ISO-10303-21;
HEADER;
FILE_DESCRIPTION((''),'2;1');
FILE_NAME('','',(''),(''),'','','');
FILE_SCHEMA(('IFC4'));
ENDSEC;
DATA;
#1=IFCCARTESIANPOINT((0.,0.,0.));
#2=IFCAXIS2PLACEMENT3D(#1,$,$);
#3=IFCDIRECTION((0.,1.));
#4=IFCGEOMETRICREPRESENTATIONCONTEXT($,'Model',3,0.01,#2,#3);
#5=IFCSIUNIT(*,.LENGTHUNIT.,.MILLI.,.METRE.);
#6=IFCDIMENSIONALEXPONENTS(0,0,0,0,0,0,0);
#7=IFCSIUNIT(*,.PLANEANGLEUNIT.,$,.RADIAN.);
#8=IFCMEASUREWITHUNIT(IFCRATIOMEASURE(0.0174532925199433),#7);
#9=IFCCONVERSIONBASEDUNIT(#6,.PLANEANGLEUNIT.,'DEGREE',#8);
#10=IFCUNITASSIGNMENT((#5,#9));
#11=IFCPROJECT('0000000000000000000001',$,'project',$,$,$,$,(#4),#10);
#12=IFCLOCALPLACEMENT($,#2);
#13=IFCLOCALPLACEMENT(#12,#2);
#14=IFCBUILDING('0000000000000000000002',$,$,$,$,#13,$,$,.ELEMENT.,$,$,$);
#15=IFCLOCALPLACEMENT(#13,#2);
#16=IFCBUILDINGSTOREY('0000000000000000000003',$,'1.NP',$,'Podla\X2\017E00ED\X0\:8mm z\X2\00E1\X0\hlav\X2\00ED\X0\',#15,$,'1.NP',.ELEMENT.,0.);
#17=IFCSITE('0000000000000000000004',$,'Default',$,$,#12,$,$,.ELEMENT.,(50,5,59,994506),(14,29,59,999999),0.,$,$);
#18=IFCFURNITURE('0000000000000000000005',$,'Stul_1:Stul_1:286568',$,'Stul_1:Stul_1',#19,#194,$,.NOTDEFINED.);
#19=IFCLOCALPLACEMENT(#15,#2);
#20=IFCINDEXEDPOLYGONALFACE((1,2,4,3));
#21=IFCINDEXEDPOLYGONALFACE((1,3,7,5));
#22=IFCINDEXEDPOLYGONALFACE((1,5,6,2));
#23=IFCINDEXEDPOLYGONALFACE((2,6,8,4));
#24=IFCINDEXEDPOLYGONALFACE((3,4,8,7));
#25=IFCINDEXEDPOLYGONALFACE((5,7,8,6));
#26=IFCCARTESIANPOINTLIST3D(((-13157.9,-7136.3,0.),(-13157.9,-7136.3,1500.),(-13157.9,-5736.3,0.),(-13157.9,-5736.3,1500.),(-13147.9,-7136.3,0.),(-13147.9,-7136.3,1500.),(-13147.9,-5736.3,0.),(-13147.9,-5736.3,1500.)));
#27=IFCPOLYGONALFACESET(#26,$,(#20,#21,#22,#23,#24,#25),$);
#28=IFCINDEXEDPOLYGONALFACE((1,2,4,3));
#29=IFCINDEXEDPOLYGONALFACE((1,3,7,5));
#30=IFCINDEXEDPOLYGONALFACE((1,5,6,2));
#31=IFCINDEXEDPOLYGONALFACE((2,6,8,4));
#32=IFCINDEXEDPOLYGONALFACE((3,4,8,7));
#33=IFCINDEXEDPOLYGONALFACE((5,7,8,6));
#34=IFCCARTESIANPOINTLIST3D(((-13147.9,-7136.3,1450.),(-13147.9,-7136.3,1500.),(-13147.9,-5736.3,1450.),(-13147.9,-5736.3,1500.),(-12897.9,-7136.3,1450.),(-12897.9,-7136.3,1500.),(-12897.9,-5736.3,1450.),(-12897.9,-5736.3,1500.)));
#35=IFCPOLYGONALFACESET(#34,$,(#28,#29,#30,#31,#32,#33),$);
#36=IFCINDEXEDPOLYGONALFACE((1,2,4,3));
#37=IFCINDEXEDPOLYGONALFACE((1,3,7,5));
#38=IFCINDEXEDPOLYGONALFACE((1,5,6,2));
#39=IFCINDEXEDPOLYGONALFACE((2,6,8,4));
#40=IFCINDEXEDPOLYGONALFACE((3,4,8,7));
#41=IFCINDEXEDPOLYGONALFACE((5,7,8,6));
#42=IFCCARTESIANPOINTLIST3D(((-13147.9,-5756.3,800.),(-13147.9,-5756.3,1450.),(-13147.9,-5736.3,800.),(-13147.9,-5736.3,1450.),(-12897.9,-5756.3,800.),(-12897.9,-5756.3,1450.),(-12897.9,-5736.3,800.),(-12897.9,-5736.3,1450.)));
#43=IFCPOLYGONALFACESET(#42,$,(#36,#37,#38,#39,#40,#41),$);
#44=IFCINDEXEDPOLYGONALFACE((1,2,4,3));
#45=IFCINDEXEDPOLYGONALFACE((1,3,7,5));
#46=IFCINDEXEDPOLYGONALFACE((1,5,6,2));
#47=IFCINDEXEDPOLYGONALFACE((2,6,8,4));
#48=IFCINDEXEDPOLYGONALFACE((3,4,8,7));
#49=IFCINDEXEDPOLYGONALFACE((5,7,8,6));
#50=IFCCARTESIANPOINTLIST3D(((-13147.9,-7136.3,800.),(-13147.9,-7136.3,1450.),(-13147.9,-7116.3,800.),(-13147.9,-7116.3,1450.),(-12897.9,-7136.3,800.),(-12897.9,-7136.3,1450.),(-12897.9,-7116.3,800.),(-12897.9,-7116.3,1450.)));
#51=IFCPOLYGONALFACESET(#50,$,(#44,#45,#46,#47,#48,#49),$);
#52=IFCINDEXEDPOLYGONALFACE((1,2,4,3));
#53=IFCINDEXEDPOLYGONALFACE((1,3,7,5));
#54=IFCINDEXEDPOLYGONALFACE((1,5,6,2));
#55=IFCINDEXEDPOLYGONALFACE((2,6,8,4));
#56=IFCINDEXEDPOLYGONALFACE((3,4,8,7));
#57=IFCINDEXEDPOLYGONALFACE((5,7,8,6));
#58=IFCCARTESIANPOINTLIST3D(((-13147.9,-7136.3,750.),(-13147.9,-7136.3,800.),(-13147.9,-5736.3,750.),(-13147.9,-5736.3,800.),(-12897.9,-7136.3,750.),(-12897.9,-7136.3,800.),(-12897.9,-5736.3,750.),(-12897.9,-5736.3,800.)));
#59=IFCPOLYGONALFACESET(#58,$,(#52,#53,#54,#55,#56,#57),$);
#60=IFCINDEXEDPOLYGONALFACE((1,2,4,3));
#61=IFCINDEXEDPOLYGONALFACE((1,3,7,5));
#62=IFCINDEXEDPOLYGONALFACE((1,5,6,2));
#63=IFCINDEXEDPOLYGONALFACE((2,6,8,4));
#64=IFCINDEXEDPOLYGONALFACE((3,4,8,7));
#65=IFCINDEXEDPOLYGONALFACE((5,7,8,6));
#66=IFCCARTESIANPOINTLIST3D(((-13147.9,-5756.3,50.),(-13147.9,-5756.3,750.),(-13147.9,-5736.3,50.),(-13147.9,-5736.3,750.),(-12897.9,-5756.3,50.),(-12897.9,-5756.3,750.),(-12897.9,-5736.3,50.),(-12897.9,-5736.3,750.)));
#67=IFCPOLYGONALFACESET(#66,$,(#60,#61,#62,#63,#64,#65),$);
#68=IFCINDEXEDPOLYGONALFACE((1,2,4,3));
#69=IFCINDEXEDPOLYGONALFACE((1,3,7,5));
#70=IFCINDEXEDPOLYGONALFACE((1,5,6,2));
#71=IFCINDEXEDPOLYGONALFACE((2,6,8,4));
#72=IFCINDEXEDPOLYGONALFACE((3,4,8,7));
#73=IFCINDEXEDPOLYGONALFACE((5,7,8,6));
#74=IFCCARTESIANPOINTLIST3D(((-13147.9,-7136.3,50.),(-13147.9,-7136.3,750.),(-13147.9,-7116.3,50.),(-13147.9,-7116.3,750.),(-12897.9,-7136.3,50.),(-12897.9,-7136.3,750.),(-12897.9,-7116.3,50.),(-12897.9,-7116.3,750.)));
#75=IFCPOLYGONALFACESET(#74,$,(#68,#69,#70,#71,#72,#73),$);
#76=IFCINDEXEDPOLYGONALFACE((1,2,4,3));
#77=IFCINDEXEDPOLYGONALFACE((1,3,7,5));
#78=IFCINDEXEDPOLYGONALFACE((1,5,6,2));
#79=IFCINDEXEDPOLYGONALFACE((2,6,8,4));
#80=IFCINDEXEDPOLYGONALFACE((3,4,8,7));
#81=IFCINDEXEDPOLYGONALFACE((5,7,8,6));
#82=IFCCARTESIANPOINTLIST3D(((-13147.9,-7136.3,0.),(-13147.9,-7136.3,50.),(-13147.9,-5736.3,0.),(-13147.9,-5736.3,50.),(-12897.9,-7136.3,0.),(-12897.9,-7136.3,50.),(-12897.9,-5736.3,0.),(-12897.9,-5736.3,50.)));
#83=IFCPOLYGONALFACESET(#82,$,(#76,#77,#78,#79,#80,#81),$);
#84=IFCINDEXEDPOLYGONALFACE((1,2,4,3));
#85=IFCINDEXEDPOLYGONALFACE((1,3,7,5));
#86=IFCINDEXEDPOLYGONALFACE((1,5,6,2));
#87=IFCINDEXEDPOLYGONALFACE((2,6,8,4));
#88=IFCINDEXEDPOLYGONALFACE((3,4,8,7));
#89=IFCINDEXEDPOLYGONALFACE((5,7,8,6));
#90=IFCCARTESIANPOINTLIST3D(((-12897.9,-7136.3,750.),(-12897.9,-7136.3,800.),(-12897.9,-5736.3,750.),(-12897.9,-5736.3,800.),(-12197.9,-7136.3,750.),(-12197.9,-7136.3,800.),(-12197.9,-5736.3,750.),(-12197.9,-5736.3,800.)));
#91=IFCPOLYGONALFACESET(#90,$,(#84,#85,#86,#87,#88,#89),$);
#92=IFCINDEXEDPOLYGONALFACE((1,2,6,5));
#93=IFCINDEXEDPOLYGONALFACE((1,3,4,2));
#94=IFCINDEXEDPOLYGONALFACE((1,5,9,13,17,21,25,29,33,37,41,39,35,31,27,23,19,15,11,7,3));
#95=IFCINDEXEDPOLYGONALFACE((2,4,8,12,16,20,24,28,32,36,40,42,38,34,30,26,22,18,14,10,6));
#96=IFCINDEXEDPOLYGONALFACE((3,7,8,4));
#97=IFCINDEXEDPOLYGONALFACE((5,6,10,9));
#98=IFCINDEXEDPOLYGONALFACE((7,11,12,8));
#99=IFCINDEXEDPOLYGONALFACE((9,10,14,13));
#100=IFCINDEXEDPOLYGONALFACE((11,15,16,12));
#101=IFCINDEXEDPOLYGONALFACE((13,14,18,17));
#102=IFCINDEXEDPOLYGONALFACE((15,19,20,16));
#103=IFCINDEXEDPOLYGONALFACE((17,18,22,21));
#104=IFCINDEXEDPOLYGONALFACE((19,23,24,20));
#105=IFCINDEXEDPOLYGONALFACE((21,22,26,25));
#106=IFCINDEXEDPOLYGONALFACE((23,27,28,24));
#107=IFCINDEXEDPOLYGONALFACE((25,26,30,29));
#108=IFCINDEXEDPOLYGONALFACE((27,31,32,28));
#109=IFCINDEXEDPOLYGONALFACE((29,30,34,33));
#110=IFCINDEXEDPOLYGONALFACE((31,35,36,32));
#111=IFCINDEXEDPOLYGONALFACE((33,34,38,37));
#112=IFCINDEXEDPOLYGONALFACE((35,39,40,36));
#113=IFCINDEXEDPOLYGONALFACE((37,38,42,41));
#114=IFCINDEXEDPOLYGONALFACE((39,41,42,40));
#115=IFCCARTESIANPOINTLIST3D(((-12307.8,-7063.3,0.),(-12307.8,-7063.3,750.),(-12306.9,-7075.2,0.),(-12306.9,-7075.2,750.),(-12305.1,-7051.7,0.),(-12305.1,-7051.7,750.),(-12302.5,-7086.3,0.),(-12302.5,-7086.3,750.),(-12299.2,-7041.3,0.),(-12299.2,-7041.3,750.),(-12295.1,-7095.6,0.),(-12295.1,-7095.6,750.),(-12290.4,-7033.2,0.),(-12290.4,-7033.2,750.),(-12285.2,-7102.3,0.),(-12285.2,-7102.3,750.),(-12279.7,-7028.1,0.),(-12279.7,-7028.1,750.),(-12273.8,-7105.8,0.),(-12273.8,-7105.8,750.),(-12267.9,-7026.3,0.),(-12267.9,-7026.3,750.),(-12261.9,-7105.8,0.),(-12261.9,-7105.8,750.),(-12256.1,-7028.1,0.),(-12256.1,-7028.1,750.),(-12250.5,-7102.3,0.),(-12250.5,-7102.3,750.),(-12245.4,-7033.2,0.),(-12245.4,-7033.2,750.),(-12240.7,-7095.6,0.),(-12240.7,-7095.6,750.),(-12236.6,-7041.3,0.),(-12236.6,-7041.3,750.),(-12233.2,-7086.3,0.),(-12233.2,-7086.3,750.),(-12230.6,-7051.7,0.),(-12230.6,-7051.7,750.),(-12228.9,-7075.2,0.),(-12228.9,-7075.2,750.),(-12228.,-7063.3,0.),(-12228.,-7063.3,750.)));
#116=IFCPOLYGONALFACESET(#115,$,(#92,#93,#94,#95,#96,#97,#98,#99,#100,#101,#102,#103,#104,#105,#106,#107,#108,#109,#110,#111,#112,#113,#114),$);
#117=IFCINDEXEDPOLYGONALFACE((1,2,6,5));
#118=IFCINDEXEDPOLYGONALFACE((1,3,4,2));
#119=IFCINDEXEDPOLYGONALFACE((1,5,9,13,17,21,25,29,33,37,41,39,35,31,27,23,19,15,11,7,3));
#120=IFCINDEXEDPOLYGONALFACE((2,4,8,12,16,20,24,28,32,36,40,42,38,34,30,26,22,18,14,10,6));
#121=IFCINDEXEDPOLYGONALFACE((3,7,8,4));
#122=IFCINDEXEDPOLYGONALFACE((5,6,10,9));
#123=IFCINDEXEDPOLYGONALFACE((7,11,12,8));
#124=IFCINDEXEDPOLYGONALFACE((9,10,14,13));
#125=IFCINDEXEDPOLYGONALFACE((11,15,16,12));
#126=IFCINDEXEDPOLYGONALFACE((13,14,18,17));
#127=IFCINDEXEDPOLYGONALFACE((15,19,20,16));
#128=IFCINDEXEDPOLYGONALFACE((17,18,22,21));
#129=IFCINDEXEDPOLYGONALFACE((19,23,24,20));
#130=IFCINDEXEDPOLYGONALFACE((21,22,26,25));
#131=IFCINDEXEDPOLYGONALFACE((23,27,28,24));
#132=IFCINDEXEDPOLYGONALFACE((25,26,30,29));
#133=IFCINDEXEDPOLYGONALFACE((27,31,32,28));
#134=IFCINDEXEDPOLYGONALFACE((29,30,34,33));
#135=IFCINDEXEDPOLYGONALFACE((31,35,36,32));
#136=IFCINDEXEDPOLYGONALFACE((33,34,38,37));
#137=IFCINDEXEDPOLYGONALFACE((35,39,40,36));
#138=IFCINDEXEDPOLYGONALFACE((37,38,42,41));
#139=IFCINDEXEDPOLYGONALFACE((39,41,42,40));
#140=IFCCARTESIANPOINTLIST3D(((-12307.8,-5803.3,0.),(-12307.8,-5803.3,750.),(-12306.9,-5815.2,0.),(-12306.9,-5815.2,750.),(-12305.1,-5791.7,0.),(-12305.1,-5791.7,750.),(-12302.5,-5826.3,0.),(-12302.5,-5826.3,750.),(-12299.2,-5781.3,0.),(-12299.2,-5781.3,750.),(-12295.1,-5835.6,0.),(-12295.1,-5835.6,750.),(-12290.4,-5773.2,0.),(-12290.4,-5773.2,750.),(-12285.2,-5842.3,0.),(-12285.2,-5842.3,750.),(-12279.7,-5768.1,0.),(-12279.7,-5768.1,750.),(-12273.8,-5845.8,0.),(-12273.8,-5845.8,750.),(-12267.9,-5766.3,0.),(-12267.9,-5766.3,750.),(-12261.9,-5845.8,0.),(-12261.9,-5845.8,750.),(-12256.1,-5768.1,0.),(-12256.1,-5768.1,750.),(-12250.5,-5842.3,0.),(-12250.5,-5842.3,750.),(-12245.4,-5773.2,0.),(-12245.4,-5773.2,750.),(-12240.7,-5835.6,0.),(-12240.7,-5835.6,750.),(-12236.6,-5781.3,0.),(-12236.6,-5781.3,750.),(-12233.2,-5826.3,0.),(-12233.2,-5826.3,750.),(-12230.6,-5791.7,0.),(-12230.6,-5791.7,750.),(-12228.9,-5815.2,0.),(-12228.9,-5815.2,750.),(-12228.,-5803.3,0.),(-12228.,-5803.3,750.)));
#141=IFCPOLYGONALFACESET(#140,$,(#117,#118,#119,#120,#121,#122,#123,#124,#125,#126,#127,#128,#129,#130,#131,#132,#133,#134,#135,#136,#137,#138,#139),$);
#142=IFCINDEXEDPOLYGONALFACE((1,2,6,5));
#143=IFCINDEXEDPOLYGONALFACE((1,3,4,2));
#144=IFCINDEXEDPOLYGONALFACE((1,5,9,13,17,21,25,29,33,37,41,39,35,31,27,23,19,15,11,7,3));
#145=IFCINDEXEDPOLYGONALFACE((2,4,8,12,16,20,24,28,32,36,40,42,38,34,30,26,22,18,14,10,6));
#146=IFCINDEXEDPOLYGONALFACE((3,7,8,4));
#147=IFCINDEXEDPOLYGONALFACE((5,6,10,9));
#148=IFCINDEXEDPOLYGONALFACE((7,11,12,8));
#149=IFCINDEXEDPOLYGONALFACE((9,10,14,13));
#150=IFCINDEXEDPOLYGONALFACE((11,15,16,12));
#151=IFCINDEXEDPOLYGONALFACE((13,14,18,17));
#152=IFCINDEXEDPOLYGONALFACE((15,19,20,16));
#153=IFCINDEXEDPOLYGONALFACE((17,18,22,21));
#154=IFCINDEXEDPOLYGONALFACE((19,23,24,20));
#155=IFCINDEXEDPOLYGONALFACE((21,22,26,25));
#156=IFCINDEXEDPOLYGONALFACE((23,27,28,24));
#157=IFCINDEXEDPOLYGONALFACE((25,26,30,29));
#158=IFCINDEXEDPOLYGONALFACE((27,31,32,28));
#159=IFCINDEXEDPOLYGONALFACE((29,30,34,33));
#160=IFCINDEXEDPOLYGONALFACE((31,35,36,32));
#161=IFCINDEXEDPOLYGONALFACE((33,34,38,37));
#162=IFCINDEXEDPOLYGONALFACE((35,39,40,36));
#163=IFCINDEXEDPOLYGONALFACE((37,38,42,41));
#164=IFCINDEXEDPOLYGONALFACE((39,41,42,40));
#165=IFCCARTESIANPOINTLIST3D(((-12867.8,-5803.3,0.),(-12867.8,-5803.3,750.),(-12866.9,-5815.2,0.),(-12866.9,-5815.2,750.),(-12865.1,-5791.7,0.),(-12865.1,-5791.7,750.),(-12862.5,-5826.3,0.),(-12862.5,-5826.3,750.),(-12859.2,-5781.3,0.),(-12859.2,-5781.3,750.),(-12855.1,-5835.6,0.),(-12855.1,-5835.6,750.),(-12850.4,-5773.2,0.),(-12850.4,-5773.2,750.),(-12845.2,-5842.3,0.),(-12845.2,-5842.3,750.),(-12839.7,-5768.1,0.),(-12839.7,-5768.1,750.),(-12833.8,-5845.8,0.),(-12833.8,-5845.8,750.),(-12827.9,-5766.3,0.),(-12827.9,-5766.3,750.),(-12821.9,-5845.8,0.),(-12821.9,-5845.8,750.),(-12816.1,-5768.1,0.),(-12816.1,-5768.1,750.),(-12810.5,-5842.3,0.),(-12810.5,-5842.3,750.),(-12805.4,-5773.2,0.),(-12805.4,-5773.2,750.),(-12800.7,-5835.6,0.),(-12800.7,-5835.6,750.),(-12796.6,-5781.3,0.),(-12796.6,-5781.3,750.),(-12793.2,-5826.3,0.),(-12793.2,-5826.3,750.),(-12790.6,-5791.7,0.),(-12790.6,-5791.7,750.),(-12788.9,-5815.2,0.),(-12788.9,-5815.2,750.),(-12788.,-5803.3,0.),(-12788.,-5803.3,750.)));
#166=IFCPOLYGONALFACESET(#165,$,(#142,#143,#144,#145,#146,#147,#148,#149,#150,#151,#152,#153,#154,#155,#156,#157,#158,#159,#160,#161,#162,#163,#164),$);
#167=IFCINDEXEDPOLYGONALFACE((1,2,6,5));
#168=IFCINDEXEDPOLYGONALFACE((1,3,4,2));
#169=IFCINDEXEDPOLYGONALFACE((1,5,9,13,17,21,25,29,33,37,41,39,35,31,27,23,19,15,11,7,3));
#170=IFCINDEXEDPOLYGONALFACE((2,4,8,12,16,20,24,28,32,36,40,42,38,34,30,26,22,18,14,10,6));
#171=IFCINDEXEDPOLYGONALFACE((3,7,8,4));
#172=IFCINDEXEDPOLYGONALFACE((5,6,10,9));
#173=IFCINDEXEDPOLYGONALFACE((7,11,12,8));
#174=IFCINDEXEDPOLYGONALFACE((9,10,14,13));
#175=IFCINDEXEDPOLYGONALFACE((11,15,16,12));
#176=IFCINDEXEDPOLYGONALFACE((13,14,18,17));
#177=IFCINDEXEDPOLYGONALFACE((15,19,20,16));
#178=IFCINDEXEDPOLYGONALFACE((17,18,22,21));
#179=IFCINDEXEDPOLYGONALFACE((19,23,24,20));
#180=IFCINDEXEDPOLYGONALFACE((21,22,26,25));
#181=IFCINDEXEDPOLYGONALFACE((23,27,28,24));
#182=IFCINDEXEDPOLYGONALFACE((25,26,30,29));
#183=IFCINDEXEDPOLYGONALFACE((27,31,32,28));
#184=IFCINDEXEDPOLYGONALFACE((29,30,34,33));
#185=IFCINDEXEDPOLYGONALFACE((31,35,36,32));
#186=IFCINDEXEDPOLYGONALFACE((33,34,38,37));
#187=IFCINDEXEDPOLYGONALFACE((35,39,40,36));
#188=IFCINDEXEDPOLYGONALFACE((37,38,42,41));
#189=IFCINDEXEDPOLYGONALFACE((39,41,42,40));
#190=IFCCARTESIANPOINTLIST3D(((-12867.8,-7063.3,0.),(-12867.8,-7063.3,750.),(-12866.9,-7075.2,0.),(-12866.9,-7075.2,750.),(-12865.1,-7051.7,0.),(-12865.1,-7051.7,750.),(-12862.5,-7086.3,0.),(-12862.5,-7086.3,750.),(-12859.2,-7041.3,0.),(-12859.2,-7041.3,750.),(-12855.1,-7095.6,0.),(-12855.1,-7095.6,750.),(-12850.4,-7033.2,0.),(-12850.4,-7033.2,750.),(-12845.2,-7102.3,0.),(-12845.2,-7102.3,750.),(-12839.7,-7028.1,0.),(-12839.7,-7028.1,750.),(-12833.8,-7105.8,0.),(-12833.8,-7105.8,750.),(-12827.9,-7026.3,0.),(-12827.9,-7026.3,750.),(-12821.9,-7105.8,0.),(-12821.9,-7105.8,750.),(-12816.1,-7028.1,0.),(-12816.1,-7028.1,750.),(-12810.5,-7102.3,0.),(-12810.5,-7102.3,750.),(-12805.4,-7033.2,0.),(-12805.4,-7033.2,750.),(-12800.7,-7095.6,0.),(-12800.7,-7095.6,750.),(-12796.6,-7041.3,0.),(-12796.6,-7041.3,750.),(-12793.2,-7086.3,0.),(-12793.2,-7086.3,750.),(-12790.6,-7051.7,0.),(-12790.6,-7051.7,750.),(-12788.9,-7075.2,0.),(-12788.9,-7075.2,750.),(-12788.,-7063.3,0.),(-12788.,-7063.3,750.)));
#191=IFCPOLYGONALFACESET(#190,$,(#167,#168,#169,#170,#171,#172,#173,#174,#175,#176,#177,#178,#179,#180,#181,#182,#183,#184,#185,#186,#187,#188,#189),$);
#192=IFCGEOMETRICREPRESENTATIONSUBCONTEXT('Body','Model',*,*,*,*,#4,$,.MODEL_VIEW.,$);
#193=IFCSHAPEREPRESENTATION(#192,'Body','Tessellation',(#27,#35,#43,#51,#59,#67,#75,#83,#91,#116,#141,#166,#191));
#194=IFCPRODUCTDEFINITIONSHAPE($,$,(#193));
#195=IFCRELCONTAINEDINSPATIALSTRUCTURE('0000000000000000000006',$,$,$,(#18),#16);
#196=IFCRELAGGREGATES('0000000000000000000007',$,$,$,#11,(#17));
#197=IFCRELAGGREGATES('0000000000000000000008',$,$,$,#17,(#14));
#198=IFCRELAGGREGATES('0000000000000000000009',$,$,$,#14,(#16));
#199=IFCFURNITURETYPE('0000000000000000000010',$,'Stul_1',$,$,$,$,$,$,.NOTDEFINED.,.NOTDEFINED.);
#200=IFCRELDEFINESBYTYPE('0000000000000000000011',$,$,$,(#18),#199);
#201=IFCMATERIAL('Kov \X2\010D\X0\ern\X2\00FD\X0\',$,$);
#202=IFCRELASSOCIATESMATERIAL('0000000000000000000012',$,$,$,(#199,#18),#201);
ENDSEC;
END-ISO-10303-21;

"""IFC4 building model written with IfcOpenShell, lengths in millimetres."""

from ifc_helpers import new_model, entity, si_unit, converted_unit, direction, frame, frame_2d, origin, origin_2d_with_axis, place, context, subcontext, project, spatial, rectangle, circle, extrude, source, transform, mapped, material, type_object, type_shapes, element, save


model = new_model("IFC4")

# Units and contexts
model_context = context("Model", 3, precision=0.01, world=origin(), true_north=direction((0.0, 1.0)))
body_context = subcontext(model_context, "Body", "Model", "MODEL_VIEW")
ifc_project = project(units=[si_unit("LENGTHUNIT", "METRE", prefix="MILLI"), converted_unit("PLANEANGLEUNIT", "DEGREE", entity("IfcRatioMeasure", 0.0174532925199433), si_unit("PLANEANGLEUNIT", "RADIAN"), dimensions=[0, 0, 0, 0, 0, 0, 0])], contexts=[model_context])

# Site, building, storey
site_placement = place(None, origin())
site = spatial("IfcSite", under=ifc_project, at=site_placement, Name="Default", CompositionType="ELEMENT", RefLatitude=(50, 5, 59, 994506), RefLongitude=(14, 29, 59, 999999), RefElevation=0.0)
building_placement = place(site_placement, origin())
building = spatial("IfcBuilding", under=site, at=building_placement, CompositionType="ELEMENT")
storey_placement = place(building_placement, origin())
storey = spatial("IfcBuildingStorey", under=building, at=storey_placement, Name="1.NP", ObjectType="Podlaží:8mm záhlaví", LongName="1.NP", CompositionType="ELEMENT", Elevation=0.0)

# Furniture
ifc_material_1 = material(Name="Kov černý")
furniture_type = type_object("IfcFurnitureType", Name="Stul_1", AssemblyPlace="NOTDEFINED", PredefinedType="NOTDEFINED", material=ifc_material_1)
shared_shape_1 = source(origin(), body_context, "Body", "SweptSolid", [
    extrude(rectangle(XDim=1400.0, YDim=10.0, at=origin_2d_with_axis()), frame((0.0, 605.0, 0.0), z_axis=(0.0, 0.0, 1.0), x_axis=(-1.0, 0.0, 0.0)), (0.0, 0.0, 1.0), 1500.0),
    extrude(rectangle(XDim=1400.0, YDim=250.0, at=frame_2d((0.0, 0.0), x_axis=(1.0, 0.0))), frame((0.0, 475.0, 1450.0), z_axis=(0.0, 0.0, 1.0), x_axis=(-1.0, 0.0, 0.0)), (0.0, 0.0, 1.0), 50.0),
    extrude(rectangle(XDim=20.0, YDim=250.0, at=origin_2d_with_axis()), frame((690.0, 475.0, 800.0), z_axis=(0.0, 0.0, 1.0), x_axis=(-1.0, 0.0, 0.0)), (0.0, 0.0, 1.0), 650.0),
    extrude(rectangle(XDim=20.0, YDim=250.0, at=frame_2d((0.0, 0.0), x_axis=(1.0, 0.0))), frame((-690.0, 475.0, 800.0), z_axis=(0.0, 0.0, 1.0), x_axis=(-1.0, 0.0, 0.0)), (0.0, 0.0, 1.0), 650.0),
    extrude(rectangle(XDim=1400.0, YDim=250.0, at=origin_2d_with_axis()), frame((0.0, 475.0, 750.0), z_axis=(0.0, 0.0, 1.0), x_axis=(-1.0, 0.0, 0.0)), (0.0, 0.0, 1.0), 50.0),
    extrude(rectangle(XDim=20.0, YDim=250.0, at=origin_2d_with_axis()), frame((690.0, 475.0, 50.0), z_axis=(0.0, 0.0, 1.0), x_axis=(-1.0, 0.0, 0.0)), (0.0, 0.0, 1.0), 700.0),
    extrude(rectangle(XDim=20.0, YDim=250.0, at=frame_2d((0.0, 0.0), x_axis=(1.0, 0.0))), frame((-690.0, 475.0, 50.0), z_axis=(0.0, 0.0, 1.0), x_axis=(-1.0, 0.0, 0.0)), (0.0, 0.0, 1.0), 700.0),
    extrude(rectangle(XDim=1400.0, YDim=250.0, at=origin_2d_with_axis()), frame((0.0, 475.0, 0.0), z_axis=(0.0, 0.0, 1.0), x_axis=(-1.0, 0.0, 0.0)), (0.0, 0.0, 1.0), 50.0),
    extrude(rectangle(XDim=1400.0, YDim=700.0, at=origin_2d_with_axis()), frame((0.0, 0.0, 750.0), z_axis=(0.0, 0.0, 1.0), x_axis=(-1.0, 0.0, 0.0)), (0.0, 0.0, 1.0), 50.0),
    extrude(circle(Radius=40.0, at=frame_2d((0.0, 0.0), x_axis=(1.0, 0.0))), frame((-630.0, -280.0, 0.0)), (0.0, 0.0, 1.0), 750.0),
    extrude(circle(Radius=40.0, at=frame_2d((0.0, 0.0), x_axis=(1.0, 0.0))), frame((630.0, -280.0, 0.0)), (0.0, 0.0, 1.0), 750.0),
    extrude(circle(Radius=40.0, at=frame_2d((0.0, 0.0), x_axis=(1.0, 0.0))), frame((630.0, 280.0, 0.0)), (0.0, 0.0, 1.0), 750.0),
    extrude(circle(Radius=40.0, at=frame_2d((0.0, 0.0), x_axis=(1.0, 0.0))), frame((-630.0, 280.0, 0.0)), (0.0, 0.0, 1.0), 750.0),
])
type_shapes(furniture_type, [shared_shape_1])
for number, where, z_axis, x_axis, name in (
    (1, (-12547.9, -6436.3, 0.0), (0.0, 0.0, 1.0), (0.0, 1.0, 0.0), "Stul_1:Stul_1:286568"),
):
    element("IfcFurniture", number, at=place(storey_placement, frame(where, z_axis=z_axis, x_axis=x_axis)), inside=storey, type_object=furniture_type, material=ifc_material_1, Name=name, ObjectType="Stul_1:Stul_1", PredefinedType="NOTDEFINED", context=body_context, shape_type="MappedRepresentation", body=[
        mapped(shared_shape_1, transform((0.0, 0.0, 0.0), scale=1.0)),
    ])

save(model, "model.ifc")
